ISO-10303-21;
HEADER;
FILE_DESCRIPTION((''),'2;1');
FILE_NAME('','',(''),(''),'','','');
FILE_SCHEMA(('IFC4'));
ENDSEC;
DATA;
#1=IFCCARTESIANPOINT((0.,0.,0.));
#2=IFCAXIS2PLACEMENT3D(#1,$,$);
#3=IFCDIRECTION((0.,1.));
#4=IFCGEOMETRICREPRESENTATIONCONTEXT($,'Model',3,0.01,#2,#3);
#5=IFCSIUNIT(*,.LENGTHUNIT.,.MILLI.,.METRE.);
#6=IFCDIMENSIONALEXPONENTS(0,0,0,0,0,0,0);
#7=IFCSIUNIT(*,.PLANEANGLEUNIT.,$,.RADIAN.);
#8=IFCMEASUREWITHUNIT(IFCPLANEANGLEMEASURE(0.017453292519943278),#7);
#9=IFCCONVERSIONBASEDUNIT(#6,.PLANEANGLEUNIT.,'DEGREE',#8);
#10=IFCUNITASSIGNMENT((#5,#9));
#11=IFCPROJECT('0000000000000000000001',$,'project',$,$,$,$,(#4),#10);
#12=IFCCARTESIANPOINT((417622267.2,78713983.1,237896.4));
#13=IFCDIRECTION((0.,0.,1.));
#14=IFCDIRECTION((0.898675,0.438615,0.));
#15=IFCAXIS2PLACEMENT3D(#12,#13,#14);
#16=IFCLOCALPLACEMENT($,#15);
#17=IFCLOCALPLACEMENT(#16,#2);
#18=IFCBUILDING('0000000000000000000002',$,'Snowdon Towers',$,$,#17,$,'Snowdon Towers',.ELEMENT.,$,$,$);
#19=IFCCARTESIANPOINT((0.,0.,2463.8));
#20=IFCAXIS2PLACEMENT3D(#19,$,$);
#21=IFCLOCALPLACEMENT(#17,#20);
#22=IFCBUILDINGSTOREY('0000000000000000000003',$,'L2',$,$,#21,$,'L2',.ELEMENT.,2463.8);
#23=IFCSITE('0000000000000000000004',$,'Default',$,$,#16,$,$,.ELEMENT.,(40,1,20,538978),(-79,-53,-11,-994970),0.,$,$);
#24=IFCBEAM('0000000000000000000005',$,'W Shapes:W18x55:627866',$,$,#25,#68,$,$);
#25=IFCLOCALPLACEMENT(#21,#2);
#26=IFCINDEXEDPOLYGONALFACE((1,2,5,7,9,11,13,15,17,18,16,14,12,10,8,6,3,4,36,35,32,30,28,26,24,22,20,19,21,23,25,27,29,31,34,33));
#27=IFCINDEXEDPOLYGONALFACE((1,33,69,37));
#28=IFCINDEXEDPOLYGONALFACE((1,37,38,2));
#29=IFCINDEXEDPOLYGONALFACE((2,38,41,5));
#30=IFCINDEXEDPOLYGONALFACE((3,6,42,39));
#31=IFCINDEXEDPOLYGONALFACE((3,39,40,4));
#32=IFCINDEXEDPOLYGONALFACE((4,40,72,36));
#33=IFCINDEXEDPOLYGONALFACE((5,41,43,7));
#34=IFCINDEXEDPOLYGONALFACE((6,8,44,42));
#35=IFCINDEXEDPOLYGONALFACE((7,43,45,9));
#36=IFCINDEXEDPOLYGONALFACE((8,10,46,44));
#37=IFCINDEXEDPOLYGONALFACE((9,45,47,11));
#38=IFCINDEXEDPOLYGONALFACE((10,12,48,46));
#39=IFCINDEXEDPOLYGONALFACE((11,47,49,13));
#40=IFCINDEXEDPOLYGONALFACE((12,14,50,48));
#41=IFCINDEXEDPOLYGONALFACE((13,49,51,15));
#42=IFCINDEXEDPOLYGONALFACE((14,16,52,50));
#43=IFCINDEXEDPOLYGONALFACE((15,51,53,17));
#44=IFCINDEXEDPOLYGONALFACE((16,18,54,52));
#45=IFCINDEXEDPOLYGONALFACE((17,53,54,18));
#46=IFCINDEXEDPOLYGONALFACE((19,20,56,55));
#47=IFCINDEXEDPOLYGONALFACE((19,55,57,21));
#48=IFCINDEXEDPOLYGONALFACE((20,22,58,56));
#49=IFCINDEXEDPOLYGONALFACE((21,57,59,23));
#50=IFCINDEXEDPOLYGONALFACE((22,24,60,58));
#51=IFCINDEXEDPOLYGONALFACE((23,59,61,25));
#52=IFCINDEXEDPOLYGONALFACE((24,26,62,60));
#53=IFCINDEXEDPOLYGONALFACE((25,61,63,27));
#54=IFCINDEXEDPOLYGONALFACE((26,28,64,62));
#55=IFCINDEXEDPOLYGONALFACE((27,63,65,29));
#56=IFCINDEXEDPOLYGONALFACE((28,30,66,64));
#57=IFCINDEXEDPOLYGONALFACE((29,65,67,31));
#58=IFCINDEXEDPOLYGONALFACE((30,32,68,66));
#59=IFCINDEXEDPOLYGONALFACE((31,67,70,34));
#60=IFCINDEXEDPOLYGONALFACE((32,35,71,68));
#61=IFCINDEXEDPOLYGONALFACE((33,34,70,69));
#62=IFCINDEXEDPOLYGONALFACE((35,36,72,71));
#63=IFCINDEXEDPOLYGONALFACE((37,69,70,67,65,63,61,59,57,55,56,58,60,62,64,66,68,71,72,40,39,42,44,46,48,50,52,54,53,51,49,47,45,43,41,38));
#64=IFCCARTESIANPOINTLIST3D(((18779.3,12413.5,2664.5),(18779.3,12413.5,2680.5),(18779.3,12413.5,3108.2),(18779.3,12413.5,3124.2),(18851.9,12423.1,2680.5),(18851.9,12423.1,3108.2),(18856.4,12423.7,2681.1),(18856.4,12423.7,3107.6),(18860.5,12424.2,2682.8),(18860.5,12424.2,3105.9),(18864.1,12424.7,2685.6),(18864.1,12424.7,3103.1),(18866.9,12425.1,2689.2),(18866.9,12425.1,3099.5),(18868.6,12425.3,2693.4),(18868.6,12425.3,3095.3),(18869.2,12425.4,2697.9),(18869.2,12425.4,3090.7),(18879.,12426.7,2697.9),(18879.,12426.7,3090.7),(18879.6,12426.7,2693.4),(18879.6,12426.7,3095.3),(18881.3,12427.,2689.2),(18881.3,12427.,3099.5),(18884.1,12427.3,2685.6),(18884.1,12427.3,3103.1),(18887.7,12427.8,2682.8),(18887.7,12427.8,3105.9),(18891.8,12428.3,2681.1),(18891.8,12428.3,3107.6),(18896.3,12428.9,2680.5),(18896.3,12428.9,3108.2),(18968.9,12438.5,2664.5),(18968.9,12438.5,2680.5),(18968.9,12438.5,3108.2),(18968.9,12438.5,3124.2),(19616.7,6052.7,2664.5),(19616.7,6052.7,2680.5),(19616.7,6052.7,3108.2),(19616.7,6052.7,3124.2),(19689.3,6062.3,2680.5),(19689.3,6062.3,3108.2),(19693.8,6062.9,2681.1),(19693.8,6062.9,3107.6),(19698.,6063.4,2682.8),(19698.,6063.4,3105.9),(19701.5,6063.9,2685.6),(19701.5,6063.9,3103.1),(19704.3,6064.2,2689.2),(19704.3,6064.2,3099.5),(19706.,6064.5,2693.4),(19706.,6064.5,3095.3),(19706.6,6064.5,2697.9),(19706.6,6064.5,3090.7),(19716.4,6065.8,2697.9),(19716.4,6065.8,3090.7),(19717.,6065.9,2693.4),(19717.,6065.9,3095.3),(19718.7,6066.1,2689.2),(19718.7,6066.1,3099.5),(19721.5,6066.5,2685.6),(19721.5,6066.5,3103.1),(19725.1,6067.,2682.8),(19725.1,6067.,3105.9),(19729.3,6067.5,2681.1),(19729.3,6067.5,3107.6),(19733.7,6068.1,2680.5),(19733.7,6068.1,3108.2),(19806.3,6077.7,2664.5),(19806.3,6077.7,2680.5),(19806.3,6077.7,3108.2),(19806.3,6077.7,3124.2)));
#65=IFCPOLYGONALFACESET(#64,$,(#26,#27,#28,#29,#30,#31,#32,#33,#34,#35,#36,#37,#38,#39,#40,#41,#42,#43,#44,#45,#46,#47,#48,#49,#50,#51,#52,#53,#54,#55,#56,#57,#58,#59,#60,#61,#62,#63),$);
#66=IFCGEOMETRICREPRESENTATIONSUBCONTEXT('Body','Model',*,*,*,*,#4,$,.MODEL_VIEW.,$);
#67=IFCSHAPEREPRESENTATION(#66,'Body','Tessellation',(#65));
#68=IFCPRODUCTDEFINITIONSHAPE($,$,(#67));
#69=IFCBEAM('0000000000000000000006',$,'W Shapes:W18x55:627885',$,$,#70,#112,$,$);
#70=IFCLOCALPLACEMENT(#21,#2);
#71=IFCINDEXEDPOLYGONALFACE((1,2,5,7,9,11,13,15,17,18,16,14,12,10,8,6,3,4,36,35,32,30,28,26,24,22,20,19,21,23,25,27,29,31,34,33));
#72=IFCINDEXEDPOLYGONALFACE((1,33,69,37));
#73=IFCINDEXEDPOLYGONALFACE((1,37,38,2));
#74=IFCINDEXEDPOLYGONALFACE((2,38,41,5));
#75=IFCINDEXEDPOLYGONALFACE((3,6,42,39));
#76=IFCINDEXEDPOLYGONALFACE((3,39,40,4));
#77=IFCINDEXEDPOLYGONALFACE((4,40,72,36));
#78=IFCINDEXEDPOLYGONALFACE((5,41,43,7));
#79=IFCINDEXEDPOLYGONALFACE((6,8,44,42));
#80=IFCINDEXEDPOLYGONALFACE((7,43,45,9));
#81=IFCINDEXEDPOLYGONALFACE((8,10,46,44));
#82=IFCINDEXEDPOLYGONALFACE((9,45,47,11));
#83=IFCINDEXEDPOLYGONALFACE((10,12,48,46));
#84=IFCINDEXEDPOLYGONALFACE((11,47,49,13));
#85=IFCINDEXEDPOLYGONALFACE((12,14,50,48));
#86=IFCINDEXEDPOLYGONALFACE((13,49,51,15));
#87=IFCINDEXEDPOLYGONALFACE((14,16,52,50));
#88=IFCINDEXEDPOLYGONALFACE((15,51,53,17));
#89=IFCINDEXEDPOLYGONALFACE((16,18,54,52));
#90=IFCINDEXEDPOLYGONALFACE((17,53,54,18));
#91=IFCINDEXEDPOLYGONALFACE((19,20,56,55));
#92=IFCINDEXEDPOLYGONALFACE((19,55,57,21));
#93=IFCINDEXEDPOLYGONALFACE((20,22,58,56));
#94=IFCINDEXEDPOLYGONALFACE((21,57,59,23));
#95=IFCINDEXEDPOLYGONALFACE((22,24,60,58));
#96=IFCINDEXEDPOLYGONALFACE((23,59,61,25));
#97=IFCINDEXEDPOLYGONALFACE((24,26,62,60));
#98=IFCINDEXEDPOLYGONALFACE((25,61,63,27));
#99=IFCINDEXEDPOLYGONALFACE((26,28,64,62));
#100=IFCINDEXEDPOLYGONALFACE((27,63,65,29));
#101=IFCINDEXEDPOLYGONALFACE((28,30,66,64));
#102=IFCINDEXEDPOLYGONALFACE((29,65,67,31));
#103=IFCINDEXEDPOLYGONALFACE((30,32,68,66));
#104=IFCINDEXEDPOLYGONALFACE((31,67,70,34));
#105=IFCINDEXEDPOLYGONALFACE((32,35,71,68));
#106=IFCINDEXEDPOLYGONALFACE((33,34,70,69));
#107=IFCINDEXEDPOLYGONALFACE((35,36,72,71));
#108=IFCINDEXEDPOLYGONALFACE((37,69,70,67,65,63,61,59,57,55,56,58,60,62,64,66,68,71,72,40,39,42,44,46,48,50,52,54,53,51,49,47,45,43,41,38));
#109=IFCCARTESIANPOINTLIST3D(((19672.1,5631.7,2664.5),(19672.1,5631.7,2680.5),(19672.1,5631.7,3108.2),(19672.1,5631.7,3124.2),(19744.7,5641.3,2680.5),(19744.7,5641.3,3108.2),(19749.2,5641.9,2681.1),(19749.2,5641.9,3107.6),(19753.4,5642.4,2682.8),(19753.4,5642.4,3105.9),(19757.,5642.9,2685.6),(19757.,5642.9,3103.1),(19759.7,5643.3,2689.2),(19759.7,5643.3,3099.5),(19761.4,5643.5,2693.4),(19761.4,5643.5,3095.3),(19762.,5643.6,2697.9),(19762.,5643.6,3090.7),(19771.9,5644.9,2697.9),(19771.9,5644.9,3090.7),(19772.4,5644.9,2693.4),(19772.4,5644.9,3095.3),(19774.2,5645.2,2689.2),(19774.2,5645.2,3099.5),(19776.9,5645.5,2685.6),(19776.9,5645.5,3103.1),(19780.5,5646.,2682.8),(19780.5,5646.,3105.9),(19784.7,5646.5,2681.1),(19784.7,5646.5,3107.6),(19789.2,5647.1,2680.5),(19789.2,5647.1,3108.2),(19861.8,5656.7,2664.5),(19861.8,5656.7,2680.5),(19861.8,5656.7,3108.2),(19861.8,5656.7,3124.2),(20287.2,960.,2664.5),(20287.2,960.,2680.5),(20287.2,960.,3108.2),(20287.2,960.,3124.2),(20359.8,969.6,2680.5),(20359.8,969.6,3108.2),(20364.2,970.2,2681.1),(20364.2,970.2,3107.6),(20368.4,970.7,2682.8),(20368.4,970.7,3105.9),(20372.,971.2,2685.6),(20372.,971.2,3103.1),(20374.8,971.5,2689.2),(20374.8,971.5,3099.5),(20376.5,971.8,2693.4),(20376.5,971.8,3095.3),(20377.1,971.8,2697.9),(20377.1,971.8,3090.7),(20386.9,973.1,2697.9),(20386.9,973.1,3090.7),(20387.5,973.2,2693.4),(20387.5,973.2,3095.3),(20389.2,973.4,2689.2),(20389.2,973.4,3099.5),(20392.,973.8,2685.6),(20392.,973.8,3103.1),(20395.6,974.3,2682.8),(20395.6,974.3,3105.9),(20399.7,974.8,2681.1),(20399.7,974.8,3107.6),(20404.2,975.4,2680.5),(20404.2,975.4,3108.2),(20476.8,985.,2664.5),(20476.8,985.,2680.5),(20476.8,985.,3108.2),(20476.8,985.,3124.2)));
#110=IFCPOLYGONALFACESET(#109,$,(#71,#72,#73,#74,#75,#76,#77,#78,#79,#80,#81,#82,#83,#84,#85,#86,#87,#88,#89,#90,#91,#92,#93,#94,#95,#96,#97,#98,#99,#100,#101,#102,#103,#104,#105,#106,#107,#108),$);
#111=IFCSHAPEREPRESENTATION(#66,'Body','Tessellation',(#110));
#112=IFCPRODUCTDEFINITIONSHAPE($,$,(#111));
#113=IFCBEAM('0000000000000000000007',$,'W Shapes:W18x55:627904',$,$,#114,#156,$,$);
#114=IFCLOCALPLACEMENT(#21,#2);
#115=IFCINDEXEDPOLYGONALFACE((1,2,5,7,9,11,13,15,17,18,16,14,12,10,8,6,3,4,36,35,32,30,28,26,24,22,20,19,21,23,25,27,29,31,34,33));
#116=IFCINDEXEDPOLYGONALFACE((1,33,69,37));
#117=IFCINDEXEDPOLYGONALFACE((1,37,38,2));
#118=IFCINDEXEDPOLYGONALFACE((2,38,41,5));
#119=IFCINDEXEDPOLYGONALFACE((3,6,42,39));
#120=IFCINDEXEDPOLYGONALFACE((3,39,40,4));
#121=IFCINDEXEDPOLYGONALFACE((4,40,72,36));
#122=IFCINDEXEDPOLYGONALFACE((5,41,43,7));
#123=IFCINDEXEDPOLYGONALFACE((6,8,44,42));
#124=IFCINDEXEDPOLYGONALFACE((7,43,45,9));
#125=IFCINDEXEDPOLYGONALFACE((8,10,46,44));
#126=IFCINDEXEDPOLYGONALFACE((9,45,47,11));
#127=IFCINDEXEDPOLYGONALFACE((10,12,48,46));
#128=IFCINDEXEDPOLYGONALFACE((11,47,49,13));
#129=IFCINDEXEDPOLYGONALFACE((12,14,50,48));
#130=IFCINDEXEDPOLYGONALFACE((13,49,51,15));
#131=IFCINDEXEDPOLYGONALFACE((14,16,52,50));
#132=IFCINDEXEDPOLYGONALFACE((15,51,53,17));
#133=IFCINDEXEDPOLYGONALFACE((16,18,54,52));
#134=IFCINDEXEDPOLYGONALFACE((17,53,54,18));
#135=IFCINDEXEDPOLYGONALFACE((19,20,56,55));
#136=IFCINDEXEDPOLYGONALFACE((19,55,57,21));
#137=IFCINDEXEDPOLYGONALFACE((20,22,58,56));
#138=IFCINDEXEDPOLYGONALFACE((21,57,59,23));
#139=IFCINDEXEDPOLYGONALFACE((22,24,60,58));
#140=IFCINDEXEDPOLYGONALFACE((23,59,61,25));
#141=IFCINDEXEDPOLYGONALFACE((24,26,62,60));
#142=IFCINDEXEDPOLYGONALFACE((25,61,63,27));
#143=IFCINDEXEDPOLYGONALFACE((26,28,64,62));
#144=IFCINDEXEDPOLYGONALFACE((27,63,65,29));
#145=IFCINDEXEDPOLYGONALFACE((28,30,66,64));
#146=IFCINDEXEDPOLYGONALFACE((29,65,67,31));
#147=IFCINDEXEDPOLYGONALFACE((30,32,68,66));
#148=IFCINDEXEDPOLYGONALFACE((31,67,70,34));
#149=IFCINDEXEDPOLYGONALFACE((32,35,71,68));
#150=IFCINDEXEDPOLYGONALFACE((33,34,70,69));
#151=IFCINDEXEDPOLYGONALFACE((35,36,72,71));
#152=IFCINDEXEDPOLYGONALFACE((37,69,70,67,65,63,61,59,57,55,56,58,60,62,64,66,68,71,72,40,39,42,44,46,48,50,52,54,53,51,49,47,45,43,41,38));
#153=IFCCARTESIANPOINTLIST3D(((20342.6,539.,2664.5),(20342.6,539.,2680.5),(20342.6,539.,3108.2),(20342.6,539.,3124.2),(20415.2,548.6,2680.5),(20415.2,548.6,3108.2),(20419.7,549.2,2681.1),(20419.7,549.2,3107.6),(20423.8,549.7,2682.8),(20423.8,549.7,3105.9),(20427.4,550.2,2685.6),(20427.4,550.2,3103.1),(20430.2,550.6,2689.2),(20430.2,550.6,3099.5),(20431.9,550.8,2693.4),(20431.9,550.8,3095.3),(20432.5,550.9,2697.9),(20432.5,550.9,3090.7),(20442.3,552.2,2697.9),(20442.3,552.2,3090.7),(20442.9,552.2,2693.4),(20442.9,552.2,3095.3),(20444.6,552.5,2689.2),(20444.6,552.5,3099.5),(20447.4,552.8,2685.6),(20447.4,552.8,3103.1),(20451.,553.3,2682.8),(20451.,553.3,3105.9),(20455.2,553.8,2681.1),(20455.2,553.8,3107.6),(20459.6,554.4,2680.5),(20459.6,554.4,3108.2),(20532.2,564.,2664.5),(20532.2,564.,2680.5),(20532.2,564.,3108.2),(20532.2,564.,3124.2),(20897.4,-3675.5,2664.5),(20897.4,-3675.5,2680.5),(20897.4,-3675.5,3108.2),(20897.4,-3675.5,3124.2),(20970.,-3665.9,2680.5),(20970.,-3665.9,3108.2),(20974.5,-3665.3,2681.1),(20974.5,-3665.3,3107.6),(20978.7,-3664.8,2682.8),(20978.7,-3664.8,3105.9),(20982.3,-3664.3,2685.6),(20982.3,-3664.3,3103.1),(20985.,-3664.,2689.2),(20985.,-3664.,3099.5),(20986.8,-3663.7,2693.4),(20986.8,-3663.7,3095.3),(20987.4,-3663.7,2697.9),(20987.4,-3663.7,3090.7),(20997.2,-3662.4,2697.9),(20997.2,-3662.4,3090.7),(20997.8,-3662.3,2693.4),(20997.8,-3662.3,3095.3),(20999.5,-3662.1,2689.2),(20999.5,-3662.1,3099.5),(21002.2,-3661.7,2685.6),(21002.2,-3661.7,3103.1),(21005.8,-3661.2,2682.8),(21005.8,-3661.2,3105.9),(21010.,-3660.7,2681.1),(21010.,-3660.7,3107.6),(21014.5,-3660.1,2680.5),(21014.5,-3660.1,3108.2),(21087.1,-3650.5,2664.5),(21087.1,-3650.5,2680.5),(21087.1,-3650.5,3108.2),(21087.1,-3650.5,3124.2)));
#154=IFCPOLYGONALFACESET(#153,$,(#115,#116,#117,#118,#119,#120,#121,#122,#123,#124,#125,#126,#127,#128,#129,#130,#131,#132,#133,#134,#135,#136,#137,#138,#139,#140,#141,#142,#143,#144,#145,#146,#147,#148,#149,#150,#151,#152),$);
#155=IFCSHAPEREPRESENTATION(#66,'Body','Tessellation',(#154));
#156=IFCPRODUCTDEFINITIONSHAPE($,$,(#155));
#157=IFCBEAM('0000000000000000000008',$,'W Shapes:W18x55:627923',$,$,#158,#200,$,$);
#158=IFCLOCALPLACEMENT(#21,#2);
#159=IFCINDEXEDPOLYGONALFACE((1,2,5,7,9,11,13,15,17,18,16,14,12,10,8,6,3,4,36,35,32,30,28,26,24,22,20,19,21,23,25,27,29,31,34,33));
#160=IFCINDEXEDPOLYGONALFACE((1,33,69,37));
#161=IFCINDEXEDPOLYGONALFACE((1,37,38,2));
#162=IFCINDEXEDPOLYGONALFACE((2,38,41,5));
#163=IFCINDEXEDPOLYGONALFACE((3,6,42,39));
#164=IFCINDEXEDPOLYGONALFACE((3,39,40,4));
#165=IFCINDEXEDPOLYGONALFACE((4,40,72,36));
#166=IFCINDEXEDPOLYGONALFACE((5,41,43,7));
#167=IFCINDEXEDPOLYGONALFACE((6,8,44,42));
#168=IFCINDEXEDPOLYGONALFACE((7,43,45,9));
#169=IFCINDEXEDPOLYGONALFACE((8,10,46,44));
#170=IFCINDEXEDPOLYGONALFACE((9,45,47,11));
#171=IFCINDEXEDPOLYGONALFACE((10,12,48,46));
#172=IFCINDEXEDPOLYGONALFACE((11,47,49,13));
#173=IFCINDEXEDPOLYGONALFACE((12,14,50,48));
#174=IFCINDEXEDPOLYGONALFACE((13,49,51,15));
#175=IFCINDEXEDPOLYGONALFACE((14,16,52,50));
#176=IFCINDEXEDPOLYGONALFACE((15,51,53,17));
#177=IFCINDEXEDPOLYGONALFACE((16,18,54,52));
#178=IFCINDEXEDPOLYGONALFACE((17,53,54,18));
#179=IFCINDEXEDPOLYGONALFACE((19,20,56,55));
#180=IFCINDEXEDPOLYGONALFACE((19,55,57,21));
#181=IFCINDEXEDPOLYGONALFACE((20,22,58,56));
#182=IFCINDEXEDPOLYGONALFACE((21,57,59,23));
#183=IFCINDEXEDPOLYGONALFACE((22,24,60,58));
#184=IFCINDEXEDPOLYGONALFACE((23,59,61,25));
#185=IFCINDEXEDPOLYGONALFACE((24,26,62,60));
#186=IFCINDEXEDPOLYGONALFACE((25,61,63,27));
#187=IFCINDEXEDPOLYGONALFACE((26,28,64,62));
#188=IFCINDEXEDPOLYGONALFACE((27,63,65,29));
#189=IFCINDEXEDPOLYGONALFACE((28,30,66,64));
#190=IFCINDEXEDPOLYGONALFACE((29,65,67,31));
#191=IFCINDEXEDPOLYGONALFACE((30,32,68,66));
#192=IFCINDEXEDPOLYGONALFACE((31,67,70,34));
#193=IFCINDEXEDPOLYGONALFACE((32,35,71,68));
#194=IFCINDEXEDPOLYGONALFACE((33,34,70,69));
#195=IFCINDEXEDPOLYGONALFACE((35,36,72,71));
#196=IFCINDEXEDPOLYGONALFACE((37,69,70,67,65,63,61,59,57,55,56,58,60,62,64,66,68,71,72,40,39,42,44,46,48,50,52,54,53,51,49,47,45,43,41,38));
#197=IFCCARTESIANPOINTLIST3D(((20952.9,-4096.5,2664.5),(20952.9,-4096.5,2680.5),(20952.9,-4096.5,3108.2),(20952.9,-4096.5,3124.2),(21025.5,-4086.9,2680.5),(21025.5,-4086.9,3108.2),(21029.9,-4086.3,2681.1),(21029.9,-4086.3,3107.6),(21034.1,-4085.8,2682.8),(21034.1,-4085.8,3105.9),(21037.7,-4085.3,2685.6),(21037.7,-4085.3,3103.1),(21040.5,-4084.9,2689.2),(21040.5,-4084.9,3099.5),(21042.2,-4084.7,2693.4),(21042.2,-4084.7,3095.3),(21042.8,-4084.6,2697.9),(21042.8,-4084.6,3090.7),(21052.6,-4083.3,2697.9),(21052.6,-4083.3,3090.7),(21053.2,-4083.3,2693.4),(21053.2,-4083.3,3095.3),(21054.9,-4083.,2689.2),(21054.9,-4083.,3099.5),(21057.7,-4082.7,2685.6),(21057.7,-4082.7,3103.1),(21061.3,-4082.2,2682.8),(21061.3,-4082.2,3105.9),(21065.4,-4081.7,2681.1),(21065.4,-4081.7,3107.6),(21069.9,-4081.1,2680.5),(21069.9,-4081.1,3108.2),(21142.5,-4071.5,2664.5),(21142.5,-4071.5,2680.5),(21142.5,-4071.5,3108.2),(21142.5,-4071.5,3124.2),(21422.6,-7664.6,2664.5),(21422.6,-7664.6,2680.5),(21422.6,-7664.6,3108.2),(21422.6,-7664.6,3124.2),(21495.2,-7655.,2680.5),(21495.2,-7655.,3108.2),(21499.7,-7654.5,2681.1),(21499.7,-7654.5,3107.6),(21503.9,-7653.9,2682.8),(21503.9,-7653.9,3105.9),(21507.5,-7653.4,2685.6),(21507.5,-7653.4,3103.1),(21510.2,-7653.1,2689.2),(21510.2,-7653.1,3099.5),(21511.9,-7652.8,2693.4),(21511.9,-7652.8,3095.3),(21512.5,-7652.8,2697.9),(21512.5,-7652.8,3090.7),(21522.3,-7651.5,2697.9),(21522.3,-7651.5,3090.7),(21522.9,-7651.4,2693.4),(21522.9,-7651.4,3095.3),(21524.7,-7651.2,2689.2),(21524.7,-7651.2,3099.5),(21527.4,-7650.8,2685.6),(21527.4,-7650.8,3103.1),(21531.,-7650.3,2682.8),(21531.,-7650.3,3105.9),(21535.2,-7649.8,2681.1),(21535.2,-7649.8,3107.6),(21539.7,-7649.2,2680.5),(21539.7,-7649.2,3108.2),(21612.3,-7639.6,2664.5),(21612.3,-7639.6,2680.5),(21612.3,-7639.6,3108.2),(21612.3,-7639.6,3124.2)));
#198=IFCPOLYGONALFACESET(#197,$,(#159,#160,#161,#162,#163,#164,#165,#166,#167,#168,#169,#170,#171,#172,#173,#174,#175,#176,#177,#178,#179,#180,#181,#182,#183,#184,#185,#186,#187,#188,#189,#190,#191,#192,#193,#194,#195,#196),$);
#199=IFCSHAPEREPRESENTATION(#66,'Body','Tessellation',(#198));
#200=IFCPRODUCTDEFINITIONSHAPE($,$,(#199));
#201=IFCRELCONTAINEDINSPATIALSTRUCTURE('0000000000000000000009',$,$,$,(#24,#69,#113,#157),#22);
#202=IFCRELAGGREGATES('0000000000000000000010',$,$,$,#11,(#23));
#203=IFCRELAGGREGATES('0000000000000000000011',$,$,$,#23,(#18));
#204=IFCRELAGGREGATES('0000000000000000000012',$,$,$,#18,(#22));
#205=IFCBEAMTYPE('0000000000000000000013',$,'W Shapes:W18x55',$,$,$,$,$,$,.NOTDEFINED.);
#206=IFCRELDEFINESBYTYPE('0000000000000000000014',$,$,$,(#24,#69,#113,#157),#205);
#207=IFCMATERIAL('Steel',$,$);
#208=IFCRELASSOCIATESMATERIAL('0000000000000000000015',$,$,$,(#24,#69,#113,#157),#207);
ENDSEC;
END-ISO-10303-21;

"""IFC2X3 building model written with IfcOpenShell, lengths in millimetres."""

from ifc_helpers import new_model, entity, si_unit, converted_unit, direction, frame, frame_2d, origin, place, context, subcontext, project, spatial, i_section, extrude, material, type_object, element, save


model = new_model("IFC2X3")

# Units and contexts
model_context = context("Model", 3, precision=0.01, world=origin(), true_north=direction((0.0, 1.0)))
body_context = subcontext(model_context, "Body", "Model", "MODEL_VIEW")
ifc_project = project(units=[si_unit("LENGTHUNIT", "METRE", prefix="MILLI"), converted_unit("PLANEANGLEUNIT", "DEGREE", entity("IfcPlaneAngleMeasure", 0.017453292519943278), si_unit("PLANEANGLEUNIT", "RADIAN"), dimensions=[0, 0, 0, 0, 0, 0, 0])], contexts=[model_context])

# Site, building, storey
site_placement = place(None, frame((417622267.2, 78713983.1, 237896.4), z_axis=(0.0, 0.0, 1.0), x_axis=(0.898675, 0.438615, 0.0)))
site = spatial("IfcSite", under=ifc_project, at=site_placement, Name="Default", CompositionType="ELEMENT", RefLatitude=(40, 1, 20, 538978), RefLongitude=(-79, -53, -11, -994970), RefElevation=0.0)
building_placement = place(site_placement, origin())
building = spatial("IfcBuilding", under=site, at=building_placement, Name="Snowdon Towers", LongName="Snowdon Towers", CompositionType="ELEMENT")
storey_placement = place(building_placement, frame((0.0, 0.0, 2463.8)))
storey = spatial("IfcBuildingStorey", under=building, at=storey_placement, Name="L2", LongName="L2", CompositionType="ELEMENT", Elevation=2463.8)

# Shared definitions
ifc_material_1 = material(Name="Steel")

# Beams
beam_type_1 = type_object("IfcBeamType", Name="W Shapes:W18x55", PredefinedType="NOTDEFINED")
beam_1_placement = place(storey_placement, frame((18842.8, 12664.1, 3124.2), z_axis=(0.0, 0.0, 1.0), x_axis=(0.130526, -0.991445, 0.0)))
element("IfcBeam", 1, at=beam_1_placement, inside=storey, type_object=beam_type_1, material=ifc_material_1, Name="W Shapes:W18x55:627866", context=body_context, shape_type="SweptSolid", body=[
    extrude(i_section(OverallWidth=191.3, OverallDepth=459.7, WebThickness=9.9, FlangeThickness=16.0, FilletRadius=17.5, at=frame_2d((0.0, 0.0), x_axis=(0.0, 1.0))), frame((240.1, 0.0, -229.9), z_axis=(1.0, 0.0, 0.0), x_axis=(0.0, 0.0, -1.0)), (0.0, 0.0, 1.0), 6415.7),
])
beam_2_placement = place(storey_placement, frame((19742.3, 5831.5, 3124.2), z_axis=(0.0, 0.0, 1.0), x_axis=(0.130526, -0.991445, 0.0)))
element("IfcBeam", 2, at=beam_2_placement, inside=storey, type_object=beam_type_1, material=ifc_material_1, Name="W Shapes:W18x55:627885", context=body_context, shape_type="SweptSolid", body=[
    extrude(i_section(OverallWidth=191.3, OverallDepth=459.7, WebThickness=9.9, FlangeThickness=16.0, FilletRadius=17.5, at=frame_2d((0.0, 0.0), x_axis=(0.0, 1.0))), frame((188.9, 0.0, -229.9), z_axis=(1.0, 0.0, 0.0), x_axis=(0.0, 0.0, -1.0)), (0.0, 0.0, 1.0), 4712.0),
])
beam_3_placement = place(storey_placement, frame((20412.8, 738.8, 3124.2), z_axis=(0.0, 0.0, 1.0), x_axis=(0.130526, -0.991445, 0.0)))
element("IfcBeam", 3, at=beam_3_placement, inside=storey, type_object=beam_type_1, material=ifc_material_1, Name="W Shapes:W18x55:627904", context=body_context, shape_type="SweptSolid", body=[
    extrude(i_section(OverallWidth=191.3, OverallDepth=459.7, WebThickness=9.9, FlangeThickness=16.0, FilletRadius=17.5, at=frame_2d((0.0, 0.0), x_axis=(0.0, 1.0))), frame((188.9, 0.0, -229.9), z_axis=(1.0, 0.0, 0.0), x_axis=(0.0, 0.0, -1.0)), (0.0, 0.0, 1.0), 4250.9),
])
beam_4_placement = place(storey_placement, frame((21023.0, -3896.7, 3124.2), z_axis=(0.0, 0.0, 1.0), x_axis=(0.130526, -0.991445, 0.0)))
element("IfcBeam", 4, at=beam_4_placement, inside=storey, type_object=beam_type_1, material=ifc_material_1, Name="W Shapes:W18x55:627923", context=body_context, shape_type="SweptSolid", body=[
    extrude(i_section(OverallWidth=191.3, OverallDepth=459.7, WebThickness=9.9, FlangeThickness=16.0, FilletRadius=17.5, at=frame_2d((0.0, 0.0), x_axis=(0.0, 1.0))), frame((188.9, 0.0, -229.9), z_axis=(1.0, 0.0, 0.0), x_axis=(0.0, 0.0, -1.0)), (0.0, 0.0, 1.0), 3598.9),
])

save(model, "model.ifc")
